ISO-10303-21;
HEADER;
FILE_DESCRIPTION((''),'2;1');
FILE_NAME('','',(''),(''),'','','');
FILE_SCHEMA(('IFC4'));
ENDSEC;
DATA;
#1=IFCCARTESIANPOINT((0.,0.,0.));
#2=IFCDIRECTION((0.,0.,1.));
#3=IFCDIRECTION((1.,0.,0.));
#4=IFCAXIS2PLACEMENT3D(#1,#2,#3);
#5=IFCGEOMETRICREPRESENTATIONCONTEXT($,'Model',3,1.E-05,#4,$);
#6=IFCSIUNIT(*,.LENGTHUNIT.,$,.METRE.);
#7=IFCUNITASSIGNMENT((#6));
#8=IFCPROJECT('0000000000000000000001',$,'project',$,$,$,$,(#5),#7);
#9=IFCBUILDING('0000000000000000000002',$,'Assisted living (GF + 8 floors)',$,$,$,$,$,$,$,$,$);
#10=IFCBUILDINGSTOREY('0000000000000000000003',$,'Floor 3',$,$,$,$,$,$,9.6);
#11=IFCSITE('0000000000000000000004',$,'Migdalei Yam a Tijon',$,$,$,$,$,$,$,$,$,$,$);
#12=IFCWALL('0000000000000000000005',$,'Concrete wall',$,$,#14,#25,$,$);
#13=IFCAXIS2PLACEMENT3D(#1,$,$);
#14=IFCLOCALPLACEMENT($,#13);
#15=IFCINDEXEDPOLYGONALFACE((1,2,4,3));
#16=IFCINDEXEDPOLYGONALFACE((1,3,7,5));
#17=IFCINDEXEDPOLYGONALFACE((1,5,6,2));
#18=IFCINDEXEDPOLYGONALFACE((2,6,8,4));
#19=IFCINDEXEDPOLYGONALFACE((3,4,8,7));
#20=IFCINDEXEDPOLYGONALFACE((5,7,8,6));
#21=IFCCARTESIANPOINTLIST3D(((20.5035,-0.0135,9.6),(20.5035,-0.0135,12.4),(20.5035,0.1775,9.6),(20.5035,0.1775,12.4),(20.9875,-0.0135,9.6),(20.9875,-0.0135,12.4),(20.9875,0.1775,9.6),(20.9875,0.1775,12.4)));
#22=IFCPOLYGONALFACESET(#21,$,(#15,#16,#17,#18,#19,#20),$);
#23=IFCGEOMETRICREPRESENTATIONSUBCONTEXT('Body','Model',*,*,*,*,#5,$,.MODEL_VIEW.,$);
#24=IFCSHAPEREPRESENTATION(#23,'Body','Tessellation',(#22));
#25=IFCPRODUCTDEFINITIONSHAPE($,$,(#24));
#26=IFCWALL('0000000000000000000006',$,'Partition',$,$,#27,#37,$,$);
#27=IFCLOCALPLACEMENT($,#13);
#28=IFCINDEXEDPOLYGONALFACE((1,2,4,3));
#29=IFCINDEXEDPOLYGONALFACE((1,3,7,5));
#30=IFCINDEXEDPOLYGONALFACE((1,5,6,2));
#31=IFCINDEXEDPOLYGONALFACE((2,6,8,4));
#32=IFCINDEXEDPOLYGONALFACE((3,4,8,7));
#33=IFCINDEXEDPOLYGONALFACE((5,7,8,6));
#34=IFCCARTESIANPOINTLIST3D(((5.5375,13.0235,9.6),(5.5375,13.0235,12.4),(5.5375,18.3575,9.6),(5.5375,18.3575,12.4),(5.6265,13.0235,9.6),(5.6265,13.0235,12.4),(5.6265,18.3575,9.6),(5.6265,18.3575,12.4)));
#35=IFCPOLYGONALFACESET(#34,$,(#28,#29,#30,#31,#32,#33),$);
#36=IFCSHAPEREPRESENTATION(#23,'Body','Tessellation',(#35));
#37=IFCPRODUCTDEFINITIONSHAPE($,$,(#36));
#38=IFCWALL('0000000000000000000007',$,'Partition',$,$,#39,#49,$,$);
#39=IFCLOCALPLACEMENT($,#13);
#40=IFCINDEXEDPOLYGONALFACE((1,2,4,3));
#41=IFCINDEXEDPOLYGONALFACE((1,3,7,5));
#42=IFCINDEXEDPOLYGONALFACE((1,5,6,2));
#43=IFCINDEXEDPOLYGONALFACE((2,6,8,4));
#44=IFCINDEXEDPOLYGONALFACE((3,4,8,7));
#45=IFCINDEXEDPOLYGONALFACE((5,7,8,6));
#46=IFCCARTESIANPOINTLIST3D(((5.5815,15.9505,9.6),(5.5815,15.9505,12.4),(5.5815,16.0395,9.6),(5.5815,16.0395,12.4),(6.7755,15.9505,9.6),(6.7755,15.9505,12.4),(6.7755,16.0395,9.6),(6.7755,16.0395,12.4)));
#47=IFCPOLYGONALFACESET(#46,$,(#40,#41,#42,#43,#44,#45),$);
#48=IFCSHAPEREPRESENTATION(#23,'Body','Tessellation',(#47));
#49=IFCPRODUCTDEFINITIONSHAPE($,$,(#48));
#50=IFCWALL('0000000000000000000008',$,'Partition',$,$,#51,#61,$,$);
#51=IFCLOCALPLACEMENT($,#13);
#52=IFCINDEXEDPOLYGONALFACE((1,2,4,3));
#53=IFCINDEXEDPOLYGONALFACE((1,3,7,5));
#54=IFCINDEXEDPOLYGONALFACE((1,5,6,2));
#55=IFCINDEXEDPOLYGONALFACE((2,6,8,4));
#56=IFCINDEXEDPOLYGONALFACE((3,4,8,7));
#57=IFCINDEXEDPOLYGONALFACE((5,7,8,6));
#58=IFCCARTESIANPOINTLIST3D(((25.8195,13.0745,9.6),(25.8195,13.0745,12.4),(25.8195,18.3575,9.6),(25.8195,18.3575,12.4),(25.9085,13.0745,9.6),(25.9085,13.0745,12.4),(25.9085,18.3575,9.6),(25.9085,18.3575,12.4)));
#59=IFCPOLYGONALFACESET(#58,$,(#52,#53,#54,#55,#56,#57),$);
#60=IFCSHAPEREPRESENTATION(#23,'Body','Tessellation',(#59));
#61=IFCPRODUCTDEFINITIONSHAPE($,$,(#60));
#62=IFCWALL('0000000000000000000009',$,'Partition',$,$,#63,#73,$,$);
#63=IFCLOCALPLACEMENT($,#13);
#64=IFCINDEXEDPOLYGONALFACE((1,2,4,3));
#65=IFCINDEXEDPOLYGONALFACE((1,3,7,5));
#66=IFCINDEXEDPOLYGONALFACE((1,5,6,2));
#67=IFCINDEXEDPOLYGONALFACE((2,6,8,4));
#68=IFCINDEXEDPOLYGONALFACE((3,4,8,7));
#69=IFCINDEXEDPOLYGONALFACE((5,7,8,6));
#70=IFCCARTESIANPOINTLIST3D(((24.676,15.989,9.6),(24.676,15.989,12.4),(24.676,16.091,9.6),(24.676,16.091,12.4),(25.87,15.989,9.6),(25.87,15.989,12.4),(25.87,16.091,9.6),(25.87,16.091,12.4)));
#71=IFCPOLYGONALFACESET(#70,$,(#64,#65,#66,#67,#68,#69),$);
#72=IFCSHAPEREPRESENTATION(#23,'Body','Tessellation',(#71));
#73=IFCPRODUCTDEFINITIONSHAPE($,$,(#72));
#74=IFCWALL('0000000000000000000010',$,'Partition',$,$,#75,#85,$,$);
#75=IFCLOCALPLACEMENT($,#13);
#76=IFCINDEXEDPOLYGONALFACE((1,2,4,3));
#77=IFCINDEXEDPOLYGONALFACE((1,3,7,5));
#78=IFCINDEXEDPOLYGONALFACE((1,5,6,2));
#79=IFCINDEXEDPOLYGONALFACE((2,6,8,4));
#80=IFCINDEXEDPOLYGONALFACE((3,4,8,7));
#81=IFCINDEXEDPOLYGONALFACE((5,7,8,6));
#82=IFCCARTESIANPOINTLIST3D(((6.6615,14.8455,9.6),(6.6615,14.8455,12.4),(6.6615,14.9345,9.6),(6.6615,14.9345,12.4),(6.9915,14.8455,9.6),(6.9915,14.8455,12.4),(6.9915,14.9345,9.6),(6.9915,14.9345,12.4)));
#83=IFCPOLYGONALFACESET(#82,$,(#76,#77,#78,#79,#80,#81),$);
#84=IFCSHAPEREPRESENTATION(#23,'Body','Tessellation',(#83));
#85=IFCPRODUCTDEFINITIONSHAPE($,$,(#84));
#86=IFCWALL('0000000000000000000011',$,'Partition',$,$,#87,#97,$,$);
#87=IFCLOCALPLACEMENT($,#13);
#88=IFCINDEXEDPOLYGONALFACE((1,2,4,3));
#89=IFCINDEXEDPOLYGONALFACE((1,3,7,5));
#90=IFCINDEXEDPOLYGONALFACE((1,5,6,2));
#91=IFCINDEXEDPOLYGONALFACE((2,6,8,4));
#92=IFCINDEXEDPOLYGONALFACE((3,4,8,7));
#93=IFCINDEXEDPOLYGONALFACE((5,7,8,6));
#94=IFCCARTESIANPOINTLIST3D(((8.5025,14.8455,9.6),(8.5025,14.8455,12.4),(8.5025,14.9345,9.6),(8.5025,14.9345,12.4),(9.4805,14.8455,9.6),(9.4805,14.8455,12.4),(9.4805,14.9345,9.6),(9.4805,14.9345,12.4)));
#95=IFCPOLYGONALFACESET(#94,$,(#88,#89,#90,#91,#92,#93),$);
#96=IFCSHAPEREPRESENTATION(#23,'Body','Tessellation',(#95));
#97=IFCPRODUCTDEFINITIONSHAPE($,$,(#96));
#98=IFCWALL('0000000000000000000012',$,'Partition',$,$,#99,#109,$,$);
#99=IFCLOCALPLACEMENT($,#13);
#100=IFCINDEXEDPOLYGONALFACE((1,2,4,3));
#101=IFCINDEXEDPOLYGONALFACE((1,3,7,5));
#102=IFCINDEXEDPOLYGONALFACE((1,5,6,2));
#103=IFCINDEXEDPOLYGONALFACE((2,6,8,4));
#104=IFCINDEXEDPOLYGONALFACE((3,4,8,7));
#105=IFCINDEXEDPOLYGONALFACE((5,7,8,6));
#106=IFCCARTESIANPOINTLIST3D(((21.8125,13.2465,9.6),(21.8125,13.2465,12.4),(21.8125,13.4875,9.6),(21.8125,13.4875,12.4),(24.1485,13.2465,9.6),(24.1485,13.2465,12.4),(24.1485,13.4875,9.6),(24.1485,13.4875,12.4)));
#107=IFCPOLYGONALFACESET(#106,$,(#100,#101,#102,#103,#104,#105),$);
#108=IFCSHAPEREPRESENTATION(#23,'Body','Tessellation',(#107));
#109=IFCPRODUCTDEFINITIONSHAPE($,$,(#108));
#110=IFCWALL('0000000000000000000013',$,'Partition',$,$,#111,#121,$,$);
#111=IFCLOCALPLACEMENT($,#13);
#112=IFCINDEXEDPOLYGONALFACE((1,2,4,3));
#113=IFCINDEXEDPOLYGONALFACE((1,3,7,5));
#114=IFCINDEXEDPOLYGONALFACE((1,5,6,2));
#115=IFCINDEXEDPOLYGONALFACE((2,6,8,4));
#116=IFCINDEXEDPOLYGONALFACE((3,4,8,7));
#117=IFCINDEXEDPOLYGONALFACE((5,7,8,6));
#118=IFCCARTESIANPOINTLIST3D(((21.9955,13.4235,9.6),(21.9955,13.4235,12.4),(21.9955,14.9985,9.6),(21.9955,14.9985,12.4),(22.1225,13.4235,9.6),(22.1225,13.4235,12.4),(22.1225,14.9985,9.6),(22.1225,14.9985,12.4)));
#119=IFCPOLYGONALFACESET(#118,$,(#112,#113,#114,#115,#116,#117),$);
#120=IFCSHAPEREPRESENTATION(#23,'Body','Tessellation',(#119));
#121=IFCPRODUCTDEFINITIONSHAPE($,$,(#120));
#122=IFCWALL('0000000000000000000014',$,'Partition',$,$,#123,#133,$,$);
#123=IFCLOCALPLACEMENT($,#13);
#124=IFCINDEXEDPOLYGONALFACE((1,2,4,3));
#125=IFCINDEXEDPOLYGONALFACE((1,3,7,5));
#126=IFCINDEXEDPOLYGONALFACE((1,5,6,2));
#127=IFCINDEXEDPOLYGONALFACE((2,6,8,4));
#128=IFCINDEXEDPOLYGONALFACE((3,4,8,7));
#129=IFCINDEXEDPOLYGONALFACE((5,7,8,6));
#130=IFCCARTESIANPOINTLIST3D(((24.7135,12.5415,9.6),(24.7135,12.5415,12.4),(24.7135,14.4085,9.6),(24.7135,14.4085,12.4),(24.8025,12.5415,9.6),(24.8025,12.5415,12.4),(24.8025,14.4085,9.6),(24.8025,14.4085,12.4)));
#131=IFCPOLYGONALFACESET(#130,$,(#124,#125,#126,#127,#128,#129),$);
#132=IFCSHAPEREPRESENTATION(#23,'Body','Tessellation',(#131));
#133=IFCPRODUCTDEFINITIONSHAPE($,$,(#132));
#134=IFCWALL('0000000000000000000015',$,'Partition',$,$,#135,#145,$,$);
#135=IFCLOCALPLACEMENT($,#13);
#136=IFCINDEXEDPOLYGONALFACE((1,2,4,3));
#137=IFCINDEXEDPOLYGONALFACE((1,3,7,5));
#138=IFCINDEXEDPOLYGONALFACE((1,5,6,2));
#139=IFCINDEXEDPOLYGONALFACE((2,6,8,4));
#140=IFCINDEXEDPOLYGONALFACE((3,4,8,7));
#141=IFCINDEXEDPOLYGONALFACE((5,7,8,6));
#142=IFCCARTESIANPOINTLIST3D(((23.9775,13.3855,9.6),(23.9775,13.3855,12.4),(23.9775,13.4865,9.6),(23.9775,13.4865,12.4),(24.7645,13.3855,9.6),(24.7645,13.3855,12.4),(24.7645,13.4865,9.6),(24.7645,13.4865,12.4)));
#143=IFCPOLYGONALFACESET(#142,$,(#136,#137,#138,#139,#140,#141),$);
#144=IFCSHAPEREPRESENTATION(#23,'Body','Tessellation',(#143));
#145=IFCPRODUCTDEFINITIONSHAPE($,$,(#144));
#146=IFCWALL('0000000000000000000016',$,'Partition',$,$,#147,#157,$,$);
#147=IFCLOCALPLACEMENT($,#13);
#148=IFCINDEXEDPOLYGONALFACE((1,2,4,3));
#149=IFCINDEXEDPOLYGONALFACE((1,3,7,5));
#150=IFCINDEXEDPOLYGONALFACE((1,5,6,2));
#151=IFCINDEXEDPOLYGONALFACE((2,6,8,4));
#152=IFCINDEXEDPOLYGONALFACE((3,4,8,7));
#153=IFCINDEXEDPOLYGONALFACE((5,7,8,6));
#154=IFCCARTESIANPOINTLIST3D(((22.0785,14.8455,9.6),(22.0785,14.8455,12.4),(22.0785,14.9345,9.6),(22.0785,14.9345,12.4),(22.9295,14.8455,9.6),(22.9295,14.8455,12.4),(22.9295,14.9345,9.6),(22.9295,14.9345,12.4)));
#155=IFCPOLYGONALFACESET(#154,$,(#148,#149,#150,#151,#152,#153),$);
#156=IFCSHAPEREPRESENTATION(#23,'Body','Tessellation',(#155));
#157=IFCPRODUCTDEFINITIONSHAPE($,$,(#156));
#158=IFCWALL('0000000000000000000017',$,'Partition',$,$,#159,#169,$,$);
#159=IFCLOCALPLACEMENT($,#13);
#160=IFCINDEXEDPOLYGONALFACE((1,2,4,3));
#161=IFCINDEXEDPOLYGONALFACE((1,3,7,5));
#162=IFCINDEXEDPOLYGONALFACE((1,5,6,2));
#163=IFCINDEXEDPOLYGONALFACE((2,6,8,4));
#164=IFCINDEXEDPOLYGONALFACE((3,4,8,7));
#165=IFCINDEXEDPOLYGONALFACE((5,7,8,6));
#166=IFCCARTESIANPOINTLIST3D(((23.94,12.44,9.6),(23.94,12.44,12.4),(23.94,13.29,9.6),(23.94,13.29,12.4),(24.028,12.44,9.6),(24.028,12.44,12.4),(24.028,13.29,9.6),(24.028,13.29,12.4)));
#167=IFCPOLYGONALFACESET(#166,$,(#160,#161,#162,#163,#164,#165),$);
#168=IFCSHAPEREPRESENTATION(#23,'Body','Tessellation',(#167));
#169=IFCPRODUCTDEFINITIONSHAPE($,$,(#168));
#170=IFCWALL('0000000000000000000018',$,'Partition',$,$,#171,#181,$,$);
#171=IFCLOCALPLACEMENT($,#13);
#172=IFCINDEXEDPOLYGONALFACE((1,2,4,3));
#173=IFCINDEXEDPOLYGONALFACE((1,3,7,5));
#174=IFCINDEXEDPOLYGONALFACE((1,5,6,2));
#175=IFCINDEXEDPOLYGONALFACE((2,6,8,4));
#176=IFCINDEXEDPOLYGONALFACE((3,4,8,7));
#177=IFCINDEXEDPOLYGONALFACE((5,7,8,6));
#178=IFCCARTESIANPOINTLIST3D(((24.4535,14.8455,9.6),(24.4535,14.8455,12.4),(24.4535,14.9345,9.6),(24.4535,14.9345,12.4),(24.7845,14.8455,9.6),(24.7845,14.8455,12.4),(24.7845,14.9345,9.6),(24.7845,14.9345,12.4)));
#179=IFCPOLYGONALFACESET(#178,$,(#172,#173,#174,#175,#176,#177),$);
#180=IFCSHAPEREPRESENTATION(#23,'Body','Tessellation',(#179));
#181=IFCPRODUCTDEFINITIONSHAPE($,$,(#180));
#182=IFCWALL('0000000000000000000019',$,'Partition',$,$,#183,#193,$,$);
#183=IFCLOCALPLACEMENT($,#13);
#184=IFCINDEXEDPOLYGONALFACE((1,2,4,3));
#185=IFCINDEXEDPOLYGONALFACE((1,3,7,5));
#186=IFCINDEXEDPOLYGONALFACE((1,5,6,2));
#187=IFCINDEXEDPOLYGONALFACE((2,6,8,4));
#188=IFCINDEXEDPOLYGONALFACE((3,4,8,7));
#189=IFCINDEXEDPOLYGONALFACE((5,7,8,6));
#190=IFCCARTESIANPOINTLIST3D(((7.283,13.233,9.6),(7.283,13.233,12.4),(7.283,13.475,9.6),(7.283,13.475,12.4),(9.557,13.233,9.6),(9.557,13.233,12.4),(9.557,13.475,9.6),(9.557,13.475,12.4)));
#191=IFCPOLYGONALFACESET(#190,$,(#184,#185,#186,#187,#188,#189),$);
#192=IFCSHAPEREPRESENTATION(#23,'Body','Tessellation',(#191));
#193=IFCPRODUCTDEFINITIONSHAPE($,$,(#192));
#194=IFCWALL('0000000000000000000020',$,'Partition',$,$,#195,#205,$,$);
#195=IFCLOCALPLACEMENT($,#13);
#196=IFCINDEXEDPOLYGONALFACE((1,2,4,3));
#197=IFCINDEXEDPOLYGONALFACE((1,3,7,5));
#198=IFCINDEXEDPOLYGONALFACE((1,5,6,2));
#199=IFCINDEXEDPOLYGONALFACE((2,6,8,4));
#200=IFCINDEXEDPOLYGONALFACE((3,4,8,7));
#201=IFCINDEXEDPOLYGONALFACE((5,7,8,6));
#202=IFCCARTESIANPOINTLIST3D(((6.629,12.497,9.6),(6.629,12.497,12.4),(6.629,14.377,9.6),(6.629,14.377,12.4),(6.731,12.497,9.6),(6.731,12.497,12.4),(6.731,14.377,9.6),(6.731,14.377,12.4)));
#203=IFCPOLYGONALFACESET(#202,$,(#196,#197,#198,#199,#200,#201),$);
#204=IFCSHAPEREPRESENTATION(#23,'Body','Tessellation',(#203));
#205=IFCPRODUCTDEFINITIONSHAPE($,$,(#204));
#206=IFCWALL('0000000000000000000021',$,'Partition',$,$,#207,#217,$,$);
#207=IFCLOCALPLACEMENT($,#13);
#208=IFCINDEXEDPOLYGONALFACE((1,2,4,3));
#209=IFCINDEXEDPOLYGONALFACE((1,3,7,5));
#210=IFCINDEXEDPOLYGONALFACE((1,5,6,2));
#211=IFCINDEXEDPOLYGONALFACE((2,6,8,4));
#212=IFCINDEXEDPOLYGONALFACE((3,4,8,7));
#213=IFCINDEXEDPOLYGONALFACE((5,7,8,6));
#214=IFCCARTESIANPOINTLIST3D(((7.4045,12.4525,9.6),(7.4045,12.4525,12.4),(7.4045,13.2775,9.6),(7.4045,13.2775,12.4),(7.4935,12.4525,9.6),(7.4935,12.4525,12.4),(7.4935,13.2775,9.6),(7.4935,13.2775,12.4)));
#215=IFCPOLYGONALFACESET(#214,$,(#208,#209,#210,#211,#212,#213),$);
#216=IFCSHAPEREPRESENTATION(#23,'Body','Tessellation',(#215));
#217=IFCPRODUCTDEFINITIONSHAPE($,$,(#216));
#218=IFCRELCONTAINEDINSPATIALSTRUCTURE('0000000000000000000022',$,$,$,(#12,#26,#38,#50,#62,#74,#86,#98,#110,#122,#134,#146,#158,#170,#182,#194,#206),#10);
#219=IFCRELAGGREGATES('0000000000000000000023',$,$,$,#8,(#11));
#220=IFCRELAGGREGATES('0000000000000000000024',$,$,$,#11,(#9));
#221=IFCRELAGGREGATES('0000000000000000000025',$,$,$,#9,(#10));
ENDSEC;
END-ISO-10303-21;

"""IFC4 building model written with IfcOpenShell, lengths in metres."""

from ifc_helpers import new_model, si_unit, frame, origin_with_axes, context, subcontext, project, spatial, line, indexed_curve, outline, extrude, element, save


model = new_model("IFC4")

# Units and contexts
model_context = context("Model", 3, precision=1e-05, world=origin_with_axes())
body_context = subcontext(model_context, "Body", "Model", "MODEL_VIEW")
ifc_project = project(units=[si_unit("LENGTHUNIT", "METRE")], contexts=[model_context])

# Site, building, storey
site = spatial("IfcSite", under=ifc_project, Name="Migdalei Yam a Tijon")
building = spatial("IfcBuilding", under=site, Name="Assisted living (GF + 8 floors)")
storey = spatial("IfcBuildingStorey", under=building, Name="Floor 3", Elevation=9.6)

# Walls
element("IfcWall", 1, inside=storey, Name="Concrete wall", context=body_context, shape_type="SweptSolid", body=[
    extrude(outline(indexed_curve([(0.0, 0.0), (0.484, 0.0), (0.484, 0.191), (0.0, 0.191)], segments=[line(1, 2, 3, 4, 1)])), frame((20.5035, -0.0135, 9.6), z_axis=(0.0, 0.0, 1.0), x_axis=(1.0, 0.0, 0.0)), (0.0, 0.0, 1.0), 2.8),
])
element("IfcWall", 2, inside=storey, Name="Partition", context=body_context, shape_type="SweptSolid", body=[
    extrude(outline(indexed_curve([(0.0, 0.0), (0.089, 0.0), (0.089, 5.334), (0.0, 5.334)], segments=[line(1, 2, 3, 4, 1)])), frame((5.5375, 13.0235, 9.6), z_axis=(0.0, 0.0, 1.0), x_axis=(1.0, 0.0, 0.0)), (0.0, 0.0, 1.0), 2.8),
])
element("IfcWall", 3, inside=storey, Name="Partition", context=body_context, shape_type="SweptSolid", body=[
    extrude(outline(indexed_curve([(0.0, 0.0), (1.194, 0.0), (1.194, 0.089), (0.0, 0.089)], segments=[line(1, 2, 3, 4, 1)])), frame((5.5815, 15.9505, 9.6), z_axis=(0.0, 0.0, 1.0), x_axis=(1.0, 0.0, 0.0)), (0.0, 0.0, 1.0), 2.8),
])
element("IfcWall", 4, inside=storey, Name="Partition", context=body_context, shape_type="SweptSolid", body=[
    extrude(outline(indexed_curve([(0.0, 0.0), (0.089, 0.0), (0.089, 5.283), (0.0, 5.283)], segments=[line(1, 2, 3, 4, 1)])), frame((25.8195, 13.0745, 9.6), z_axis=(0.0, 0.0, 1.0), x_axis=(1.0, 0.0, 0.0)), (0.0, 0.0, 1.0), 2.8),
])
element("IfcWall", 5, inside=storey, Name="Partition", context=body_context, shape_type="SweptSolid", body=[
    extrude(outline(indexed_curve([(0.0, 0.0), (1.194, 0.0), (1.194, 0.102), (0.0, 0.102)], segments=[line(1, 2, 3, 4, 1)])), frame((24.676, 15.989, 9.6), z_axis=(0.0, 0.0, 1.0), x_axis=(1.0, 0.0, 0.0)), (0.0, 0.0, 1.0), 2.8),
])
element("IfcWall", 6, inside=storey, Name="Partition", context=body_context, shape_type="SweptSolid", body=[
    extrude(outline(indexed_curve([(0.0, 0.0), (0.33, 0.0), (0.33, 0.089), (0.0, 0.089)], segments=[line(1, 2, 3, 4, 1)])), frame((6.6615, 14.8455, 9.6), z_axis=(0.0, 0.0, 1.0), x_axis=(1.0, 0.0, 0.0)), (0.0, 0.0, 1.0), 2.8),
])
element("IfcWall", 7, inside=storey, Name="Partition", context=body_context, shape_type="SweptSolid", body=[
    extrude(outline(indexed_curve([(0.0, 0.0), (0.978, 0.0), (0.978, 0.089), (0.0, 0.089)], segments=[line(1, 2, 3, 4, 1)])), frame((8.5025, 14.8455, 9.6), z_axis=(0.0, 0.0, 1.0), x_axis=(1.0, 0.0, 0.0)), (0.0, 0.0, 1.0), 2.8),
])
element("IfcWall", 8, inside=storey, Name="Partition", context=body_context, shape_type="SweptSolid", body=[
    extrude(outline(indexed_curve([(0.0, 0.0), (2.336, 0.0), (2.336, 0.241), (0.0, 0.241)], segments=[line(1, 2, 3, 4, 1)])), frame((21.8125, 13.2465, 9.6), z_axis=(0.0, 0.0, 1.0), x_axis=(1.0, 0.0, 0.0)), (0.0, 0.0, 1.0), 2.8),
])
element("IfcWall", 9, inside=storey, Name="Partition", context=body_context, shape_type="SweptSolid", body=[
    extrude(outline(indexed_curve([(0.0, 0.0), (0.127, 0.0), (0.127, 1.575), (0.0, 1.575)], segments=[line(1, 2, 3, 4, 1)])), frame((21.9955, 13.4235, 9.6), z_axis=(0.0, 0.0, 1.0), x_axis=(1.0, 0.0, 0.0)), (0.0, 0.0, 1.0), 2.8),
])
element("IfcWall", 10, inside=storey, Name="Partition", context=body_context, shape_type="SweptSolid", body=[
    extrude(outline(indexed_curve([(0.0, 0.0), (0.089, 0.0), (0.089, 1.867), (0.0, 1.867)], segments=[line(1, 2, 3, 4, 1)])), frame((24.7135, 12.5415, 9.6), z_axis=(0.0, 0.0, 1.0), x_axis=(1.0, 0.0, 0.0)), (0.0, 0.0, 1.0), 2.8),
])
element("IfcWall", 11, inside=storey, Name="Partition", context=body_context, shape_type="SweptSolid", body=[
    extrude(outline(indexed_curve([(0.0, 0.0), (0.787, 0.0), (0.787, 0.101), (0.0, 0.101)], segments=[line(1, 2, 3, 4, 1)])), frame((23.9775, 13.3855, 9.6), z_axis=(0.0, 0.0, 1.0), x_axis=(1.0, 0.0, 0.0)), (0.0, 0.0, 1.0), 2.8),
])
element("IfcWall", 12, inside=storey, Name="Partition", context=body_context, shape_type="SweptSolid", body=[
    extrude(outline(indexed_curve([(0.0, 0.0), (0.851, 0.0), (0.851, 0.089), (0.0, 0.089)], segments=[line(1, 2, 3, 4, 1)])), frame((22.0785, 14.8455, 9.6), z_axis=(0.0, 0.0, 1.0), x_axis=(1.0, 0.0, 0.0)), (0.0, 0.0, 1.0), 2.8),
])
element("IfcWall", 13, inside=storey, Name="Partition", context=body_context, shape_type="SweptSolid", body=[
    extrude(outline(indexed_curve([(0.0, 0.0), (0.088, 0.0), (0.088, 0.85), (0.0, 0.85)], segments=[line(1, 2, 3, 4, 1)])), frame((23.94, 12.44, 9.6), z_axis=(0.0, 0.0, 1.0), x_axis=(1.0, 0.0, 0.0)), (0.0, 0.0, 1.0), 2.8),
])
element("IfcWall", 14, inside=storey, Name="Partition", context=body_context, shape_type="SweptSolid", body=[
    extrude(outline(indexed_curve([(0.0, 0.0), (0.331, 0.0), (0.331, 0.089), (0.0, 0.089)], segments=[line(1, 2, 3, 4, 1)])), frame((24.4535, 14.8455, 9.6), z_axis=(0.0, 0.0, 1.0), x_axis=(1.0, 0.0, 0.0)), (0.0, 0.0, 1.0), 2.8),
])
element("IfcWall", 15, inside=storey, Name="Partition", context=body_context, shape_type="SweptSolid", body=[
    extrude(outline(indexed_curve([(0.0, 0.0), (2.274, 0.0), (2.274, 0.242), (0.0, 0.242)], segments=[line(1, 2, 3, 4, 1)])), frame((7.283, 13.233, 9.6), z_axis=(0.0, 0.0, 1.0), x_axis=(1.0, 0.0, 0.0)), (0.0, 0.0, 1.0), 2.8),
])
element("IfcWall", 16, inside=storey, Name="Partition", context=body_context, shape_type="SweptSolid", body=[
    extrude(outline(indexed_curve([(0.0, 0.0), (0.102, 0.0), (0.102, 1.88), (0.0, 1.88)], segments=[line(1, 2, 3, 4, 1)])), frame((6.629, 12.497, 9.6), z_axis=(0.0, 0.0, 1.0), x_axis=(1.0, 0.0, 0.0)), (0.0, 0.0, 1.0), 2.8),
])
element("IfcWall", 17, inside=storey, Name="Partition", context=body_context, shape_type="SweptSolid", body=[
    extrude(outline(indexed_curve([(0.0, 0.0), (0.089, 0.0), (0.089, 0.825), (0.0, 0.825)], segments=[line(1, 2, 3, 4, 1)])), frame((7.4045, 12.4525, 9.6), z_axis=(0.0, 0.0, 1.0), x_axis=(1.0, 0.0, 0.0)), (0.0, 0.0, 1.0), 2.8),
])

save(model, "model.ifc")
